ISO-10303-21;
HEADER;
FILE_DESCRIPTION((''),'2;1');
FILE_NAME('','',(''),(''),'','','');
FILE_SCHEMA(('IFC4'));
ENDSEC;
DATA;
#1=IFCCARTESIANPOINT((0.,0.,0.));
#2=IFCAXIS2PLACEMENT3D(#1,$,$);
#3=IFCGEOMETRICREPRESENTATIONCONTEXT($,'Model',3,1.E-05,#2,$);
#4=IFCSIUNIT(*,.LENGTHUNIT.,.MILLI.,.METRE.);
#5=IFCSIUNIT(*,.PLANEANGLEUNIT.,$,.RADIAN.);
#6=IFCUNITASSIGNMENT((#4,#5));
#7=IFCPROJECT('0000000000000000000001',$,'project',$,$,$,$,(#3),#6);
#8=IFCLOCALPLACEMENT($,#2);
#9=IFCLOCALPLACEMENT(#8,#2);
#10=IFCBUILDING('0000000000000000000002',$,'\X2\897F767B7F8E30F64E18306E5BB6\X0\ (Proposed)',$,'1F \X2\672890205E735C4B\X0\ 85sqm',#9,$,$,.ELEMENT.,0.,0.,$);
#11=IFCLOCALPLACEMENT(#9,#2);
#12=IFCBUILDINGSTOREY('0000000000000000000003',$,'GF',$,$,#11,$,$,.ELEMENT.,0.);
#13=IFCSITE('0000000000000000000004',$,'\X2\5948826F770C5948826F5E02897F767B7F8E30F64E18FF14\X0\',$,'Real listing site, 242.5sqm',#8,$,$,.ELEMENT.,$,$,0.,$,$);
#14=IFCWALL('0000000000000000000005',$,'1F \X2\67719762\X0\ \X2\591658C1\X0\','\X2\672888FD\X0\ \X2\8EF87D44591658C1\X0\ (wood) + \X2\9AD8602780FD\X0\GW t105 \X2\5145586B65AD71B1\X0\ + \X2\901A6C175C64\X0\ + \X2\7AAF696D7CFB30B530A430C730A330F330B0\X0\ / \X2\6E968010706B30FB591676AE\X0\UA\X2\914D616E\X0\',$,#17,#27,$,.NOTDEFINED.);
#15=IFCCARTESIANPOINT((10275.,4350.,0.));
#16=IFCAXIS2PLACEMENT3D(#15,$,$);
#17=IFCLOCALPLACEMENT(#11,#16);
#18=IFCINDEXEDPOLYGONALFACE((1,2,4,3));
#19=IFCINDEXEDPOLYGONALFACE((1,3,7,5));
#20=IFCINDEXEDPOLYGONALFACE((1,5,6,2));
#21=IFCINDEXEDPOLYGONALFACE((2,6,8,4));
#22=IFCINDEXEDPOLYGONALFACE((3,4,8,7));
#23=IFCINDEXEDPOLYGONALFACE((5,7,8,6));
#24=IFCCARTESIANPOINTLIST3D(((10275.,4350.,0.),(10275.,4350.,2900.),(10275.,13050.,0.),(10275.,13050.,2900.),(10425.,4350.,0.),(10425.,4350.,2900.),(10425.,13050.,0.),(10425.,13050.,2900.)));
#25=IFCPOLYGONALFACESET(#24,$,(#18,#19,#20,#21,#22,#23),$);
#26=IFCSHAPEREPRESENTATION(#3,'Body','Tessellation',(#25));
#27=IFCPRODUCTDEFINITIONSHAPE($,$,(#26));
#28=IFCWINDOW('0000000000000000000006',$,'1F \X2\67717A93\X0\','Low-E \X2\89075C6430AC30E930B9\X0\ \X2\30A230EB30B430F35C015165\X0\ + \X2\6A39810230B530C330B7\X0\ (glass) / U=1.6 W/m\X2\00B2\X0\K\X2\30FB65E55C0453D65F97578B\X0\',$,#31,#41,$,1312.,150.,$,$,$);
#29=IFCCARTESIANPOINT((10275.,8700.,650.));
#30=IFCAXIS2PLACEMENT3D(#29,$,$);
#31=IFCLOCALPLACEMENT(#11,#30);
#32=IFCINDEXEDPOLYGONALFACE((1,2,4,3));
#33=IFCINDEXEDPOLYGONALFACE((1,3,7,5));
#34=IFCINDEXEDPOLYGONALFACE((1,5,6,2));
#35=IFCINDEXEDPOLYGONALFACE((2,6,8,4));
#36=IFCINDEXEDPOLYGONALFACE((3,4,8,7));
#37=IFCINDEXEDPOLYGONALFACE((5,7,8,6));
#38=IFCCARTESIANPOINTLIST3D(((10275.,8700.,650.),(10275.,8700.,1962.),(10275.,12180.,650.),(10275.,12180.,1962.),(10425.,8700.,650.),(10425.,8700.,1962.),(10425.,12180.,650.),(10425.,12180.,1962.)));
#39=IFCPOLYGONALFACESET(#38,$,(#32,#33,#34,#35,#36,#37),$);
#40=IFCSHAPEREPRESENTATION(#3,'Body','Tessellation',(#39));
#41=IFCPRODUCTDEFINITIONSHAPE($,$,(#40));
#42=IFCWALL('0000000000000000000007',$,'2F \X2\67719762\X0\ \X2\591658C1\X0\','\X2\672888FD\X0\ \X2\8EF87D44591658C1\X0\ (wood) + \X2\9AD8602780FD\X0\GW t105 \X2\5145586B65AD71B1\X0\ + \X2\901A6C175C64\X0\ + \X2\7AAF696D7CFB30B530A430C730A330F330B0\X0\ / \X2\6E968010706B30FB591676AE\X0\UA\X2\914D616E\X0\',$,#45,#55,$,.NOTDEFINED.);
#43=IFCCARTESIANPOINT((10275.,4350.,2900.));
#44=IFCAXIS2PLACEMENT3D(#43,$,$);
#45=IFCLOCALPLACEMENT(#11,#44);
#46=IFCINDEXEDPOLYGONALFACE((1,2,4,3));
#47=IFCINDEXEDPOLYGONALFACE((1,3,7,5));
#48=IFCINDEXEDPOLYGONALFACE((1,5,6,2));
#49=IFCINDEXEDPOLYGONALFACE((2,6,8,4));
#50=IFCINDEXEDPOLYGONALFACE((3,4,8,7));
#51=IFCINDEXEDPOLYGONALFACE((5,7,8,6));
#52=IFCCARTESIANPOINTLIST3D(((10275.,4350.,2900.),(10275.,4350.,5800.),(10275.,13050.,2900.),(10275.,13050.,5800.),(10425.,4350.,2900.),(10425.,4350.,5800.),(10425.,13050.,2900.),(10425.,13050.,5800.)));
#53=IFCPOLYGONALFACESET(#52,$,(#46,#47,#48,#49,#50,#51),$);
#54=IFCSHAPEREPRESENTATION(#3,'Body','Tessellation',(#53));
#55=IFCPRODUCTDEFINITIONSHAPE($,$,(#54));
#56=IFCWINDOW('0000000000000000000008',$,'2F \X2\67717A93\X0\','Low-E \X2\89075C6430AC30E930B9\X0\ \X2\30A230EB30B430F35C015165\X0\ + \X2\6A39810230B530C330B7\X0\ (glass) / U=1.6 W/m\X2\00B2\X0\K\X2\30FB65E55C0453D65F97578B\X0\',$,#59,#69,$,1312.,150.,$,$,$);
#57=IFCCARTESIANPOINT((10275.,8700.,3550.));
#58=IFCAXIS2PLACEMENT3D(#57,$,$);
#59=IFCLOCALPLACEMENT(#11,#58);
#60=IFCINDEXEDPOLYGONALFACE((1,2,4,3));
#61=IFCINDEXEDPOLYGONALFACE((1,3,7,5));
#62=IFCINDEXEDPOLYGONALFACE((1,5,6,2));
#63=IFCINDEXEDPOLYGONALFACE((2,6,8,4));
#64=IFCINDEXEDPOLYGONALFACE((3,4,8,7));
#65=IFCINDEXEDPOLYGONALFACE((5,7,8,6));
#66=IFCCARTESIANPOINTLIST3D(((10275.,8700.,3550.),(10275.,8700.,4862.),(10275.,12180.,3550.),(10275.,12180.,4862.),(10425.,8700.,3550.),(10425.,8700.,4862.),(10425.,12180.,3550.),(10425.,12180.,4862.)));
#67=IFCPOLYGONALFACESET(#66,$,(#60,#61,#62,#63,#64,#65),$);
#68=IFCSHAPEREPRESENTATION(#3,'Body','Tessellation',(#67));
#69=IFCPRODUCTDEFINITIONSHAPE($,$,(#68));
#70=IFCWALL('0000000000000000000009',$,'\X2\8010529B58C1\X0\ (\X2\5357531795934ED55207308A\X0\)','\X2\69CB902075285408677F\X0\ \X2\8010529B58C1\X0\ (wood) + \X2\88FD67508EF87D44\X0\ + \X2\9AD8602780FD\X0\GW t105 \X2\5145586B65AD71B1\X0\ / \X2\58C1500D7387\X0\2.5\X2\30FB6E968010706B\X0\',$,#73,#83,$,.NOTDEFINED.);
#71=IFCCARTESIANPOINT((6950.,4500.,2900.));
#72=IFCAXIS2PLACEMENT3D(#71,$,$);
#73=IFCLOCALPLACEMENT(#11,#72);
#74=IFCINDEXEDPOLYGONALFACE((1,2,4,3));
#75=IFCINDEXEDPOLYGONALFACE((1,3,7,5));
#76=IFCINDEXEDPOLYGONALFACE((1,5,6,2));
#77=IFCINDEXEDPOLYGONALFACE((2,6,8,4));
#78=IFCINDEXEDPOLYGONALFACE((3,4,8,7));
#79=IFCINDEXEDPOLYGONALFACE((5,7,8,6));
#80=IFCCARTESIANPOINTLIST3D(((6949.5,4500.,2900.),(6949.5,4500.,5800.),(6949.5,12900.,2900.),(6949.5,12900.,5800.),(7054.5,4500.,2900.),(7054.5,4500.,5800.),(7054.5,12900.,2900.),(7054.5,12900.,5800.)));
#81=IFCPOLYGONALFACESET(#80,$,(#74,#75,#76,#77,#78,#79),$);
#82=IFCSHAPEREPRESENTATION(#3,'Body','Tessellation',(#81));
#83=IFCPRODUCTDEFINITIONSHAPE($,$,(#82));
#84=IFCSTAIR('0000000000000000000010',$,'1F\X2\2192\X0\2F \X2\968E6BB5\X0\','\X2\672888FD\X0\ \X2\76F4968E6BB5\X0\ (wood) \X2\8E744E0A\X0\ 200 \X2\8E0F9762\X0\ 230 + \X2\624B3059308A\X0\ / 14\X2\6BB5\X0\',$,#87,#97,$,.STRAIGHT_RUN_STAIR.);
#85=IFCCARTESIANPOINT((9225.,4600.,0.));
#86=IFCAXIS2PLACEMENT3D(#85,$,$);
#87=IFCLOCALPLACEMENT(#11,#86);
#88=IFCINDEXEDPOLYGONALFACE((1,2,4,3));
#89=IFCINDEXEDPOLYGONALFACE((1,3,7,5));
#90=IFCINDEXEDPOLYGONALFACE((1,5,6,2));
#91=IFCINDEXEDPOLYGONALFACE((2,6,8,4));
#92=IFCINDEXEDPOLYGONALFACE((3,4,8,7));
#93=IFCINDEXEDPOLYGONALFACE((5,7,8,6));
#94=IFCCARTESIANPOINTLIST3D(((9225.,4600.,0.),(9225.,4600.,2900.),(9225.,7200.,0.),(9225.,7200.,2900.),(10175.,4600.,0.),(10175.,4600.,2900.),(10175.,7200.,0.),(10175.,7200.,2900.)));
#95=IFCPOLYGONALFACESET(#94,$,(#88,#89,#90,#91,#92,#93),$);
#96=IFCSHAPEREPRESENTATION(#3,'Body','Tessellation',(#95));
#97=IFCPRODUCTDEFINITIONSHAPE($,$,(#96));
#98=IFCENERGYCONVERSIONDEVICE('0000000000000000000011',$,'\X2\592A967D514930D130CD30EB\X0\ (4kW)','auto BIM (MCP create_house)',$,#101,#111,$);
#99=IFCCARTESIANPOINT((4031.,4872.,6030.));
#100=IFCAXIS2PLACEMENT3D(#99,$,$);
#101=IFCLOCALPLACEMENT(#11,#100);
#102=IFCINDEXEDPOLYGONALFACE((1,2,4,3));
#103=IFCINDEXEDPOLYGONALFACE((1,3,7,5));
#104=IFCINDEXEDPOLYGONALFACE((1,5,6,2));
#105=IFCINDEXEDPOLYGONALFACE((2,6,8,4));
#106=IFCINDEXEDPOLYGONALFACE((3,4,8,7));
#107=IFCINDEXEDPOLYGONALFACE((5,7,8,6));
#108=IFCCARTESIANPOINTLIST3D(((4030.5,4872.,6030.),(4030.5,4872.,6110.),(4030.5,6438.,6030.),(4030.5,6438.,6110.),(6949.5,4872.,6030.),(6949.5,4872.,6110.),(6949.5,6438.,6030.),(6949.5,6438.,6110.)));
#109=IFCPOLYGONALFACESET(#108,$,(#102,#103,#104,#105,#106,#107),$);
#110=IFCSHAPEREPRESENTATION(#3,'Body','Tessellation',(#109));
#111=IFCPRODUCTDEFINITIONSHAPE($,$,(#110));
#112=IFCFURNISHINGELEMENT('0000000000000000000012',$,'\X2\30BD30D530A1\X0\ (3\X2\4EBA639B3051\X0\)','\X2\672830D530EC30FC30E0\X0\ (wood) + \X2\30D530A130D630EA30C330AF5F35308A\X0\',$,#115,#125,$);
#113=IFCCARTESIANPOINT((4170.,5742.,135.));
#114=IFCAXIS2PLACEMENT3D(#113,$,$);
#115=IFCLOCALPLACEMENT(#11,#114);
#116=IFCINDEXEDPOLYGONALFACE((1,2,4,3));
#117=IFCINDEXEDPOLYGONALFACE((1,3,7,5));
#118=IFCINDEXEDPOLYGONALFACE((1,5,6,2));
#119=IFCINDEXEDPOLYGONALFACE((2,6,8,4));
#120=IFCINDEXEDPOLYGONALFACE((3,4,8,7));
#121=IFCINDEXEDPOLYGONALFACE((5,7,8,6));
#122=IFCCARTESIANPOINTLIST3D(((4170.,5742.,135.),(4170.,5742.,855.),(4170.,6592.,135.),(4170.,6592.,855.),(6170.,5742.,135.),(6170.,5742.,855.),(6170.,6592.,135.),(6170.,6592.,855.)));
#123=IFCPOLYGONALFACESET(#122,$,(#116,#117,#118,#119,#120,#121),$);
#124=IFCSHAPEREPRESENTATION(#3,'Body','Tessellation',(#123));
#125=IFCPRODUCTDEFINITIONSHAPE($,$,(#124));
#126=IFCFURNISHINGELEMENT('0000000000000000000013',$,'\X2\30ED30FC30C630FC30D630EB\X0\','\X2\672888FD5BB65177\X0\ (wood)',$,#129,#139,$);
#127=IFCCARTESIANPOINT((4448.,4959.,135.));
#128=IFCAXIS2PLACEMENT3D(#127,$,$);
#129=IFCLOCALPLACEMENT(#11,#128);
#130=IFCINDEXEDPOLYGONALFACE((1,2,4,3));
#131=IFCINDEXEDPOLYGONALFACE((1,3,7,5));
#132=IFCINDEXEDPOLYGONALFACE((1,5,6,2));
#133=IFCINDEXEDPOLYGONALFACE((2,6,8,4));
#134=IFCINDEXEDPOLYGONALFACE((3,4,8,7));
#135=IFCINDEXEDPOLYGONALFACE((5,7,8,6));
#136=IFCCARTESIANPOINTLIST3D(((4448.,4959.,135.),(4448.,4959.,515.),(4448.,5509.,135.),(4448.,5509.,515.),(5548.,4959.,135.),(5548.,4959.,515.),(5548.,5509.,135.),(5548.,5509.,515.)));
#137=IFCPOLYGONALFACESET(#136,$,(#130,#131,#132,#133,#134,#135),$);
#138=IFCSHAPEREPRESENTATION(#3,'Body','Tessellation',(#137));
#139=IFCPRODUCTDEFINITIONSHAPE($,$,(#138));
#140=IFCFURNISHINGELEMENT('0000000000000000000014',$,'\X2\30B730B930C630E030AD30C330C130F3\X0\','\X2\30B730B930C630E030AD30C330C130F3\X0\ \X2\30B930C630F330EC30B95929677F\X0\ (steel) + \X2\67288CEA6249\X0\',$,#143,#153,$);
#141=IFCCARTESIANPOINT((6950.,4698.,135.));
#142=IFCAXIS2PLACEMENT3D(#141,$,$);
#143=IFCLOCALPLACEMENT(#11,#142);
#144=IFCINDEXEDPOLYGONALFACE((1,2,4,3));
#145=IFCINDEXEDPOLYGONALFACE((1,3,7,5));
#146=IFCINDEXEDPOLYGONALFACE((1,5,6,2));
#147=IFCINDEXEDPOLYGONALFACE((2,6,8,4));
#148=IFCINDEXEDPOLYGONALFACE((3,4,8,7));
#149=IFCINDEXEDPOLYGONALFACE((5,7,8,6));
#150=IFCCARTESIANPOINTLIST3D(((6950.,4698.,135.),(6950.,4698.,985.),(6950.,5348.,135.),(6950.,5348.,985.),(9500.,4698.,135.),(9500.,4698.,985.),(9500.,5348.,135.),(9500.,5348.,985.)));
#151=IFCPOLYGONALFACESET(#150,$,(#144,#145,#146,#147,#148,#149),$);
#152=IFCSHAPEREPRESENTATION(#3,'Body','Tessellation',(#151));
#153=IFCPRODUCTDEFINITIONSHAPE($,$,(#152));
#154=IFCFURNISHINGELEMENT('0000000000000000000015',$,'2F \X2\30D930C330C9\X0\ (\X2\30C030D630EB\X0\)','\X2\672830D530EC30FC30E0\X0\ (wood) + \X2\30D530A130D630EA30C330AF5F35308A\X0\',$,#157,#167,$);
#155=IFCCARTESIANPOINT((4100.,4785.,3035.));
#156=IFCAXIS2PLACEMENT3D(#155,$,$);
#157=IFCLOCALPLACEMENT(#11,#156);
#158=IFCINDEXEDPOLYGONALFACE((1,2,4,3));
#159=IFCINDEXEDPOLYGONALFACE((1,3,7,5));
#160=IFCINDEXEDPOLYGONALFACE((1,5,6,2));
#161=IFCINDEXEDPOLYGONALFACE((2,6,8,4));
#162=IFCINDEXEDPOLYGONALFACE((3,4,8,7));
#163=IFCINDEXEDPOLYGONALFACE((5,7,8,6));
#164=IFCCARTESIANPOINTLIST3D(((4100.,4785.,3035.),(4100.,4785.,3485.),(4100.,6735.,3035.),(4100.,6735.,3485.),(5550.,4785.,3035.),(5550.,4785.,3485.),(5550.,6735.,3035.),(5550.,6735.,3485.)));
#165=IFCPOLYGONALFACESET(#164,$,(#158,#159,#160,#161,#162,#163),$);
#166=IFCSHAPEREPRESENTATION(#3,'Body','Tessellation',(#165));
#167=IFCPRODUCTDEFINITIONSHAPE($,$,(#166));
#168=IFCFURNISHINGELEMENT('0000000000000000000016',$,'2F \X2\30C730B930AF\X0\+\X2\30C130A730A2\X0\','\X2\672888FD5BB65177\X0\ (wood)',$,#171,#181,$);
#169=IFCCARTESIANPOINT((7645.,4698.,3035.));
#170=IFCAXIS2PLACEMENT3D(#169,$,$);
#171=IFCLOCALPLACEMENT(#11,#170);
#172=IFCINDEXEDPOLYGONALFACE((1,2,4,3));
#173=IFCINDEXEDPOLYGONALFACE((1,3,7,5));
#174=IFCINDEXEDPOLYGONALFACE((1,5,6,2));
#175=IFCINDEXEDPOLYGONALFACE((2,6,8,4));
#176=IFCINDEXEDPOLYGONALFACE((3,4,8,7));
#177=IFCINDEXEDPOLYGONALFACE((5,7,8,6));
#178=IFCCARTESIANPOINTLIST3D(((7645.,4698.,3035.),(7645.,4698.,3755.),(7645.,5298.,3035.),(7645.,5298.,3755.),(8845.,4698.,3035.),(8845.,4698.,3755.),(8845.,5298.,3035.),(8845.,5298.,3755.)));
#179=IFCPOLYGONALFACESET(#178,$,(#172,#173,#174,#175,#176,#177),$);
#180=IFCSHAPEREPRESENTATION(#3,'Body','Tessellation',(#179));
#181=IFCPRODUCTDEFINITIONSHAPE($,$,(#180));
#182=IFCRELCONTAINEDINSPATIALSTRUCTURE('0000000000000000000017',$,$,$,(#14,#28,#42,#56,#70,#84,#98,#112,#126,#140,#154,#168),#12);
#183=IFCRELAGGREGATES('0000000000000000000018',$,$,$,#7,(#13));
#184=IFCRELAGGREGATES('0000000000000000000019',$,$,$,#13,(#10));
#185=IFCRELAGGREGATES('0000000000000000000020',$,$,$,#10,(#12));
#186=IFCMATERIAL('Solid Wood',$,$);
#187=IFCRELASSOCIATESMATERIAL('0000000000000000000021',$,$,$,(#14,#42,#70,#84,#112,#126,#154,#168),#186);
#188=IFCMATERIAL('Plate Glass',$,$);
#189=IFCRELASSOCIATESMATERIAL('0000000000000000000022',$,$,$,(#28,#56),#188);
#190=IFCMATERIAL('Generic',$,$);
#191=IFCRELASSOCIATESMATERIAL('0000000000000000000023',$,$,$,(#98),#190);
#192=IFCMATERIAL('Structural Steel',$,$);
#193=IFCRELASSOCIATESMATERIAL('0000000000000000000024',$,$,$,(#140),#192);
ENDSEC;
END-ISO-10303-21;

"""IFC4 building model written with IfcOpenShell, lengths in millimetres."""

from ifc_helpers import new_model, si_unit, frame, frame_2d, origin, place, context, project, spatial, rectangle, extrude, material, element, fill, save


model = new_model("IFC4")

# Units and contexts
model_context = context("Model", 3, precision=1e-05, world=origin())
ifc_project = project(units=[si_unit("LENGTHUNIT", "METRE", prefix="MILLI"), si_unit("PLANEANGLEUNIT", "RADIAN")], contexts=[model_context])

# Site, building, storey
site_placement = place(None, origin())
site = spatial("IfcSite", under=ifc_project, at=site_placement, Name="奈良県奈良市西登美ヶ丘４", ObjectType="Real listing site, 242.5sqm", CompositionType="ELEMENT", RefElevation=0.0)
building_placement = place(site_placement, origin())
building = spatial("IfcBuilding", under=site, at=building_placement, Name="西登美ヶ丘の家 (Proposed)", ObjectType="1F 木造平屋 85sqm", CompositionType="ELEMENT", ElevationOfRefHeight=0.0, ElevationOfTerrain=0.0)
storey_placement = place(building_placement, origin())
storey = spatial("IfcBuildingStorey", under=building, at=storey_placement, Name="GF", CompositionType="ELEMENT", Elevation=0.0)

# Wall, opening, window
ifc_material_1 = material(Name="Solid Wood")
wall_1_placement = place(storey_placement, frame((10275.0, 4350.0, 0.0)))
wall_1 = element("IfcWall", 1, at=wall_1_placement, inside=storey, material=ifc_material_1, Name="1F 東面 外壁", Description="木製 軸組外壁 (wood) + 高性能GW t105 充填断熱 + 通気層 + 窯業系サイディング / 準耐火・外皮UA配慮", PredefinedType="NOTDEFINED", context=model_context, shape_type="SweptSolid", body=[
    extrude(rectangle(XDim=150.0, YDim=8700.0, at=frame_2d((75.0, 4350.0))), frame((10275.0, 4350.0, 0.0)), (0.0, 0.0, 1.0), 2900.0),
])
opening_1_placement = place(storey_placement, frame((10275.0, 8700.0, 650.0)))
opening_1 = element("IfcOpeningElement", 2, at=opening_1_placement, cuts=wall_1, PredefinedType="NOTDEFINED", context=model_context, shape_type="SweptSolid", body=[
    extrude(rectangle(XDim=150.0, YDim=3480.0, at=frame_2d((75.0, 1740.0))), frame((10275.0, 8700.0, 650.0)), (0.0, 0.0, 1.0), 1312.0),
])
ifc_material_2 = material(Name="Plate Glass")
window_1_placement = place(storey_placement, frame((10275.0, 8700.0, 650.0)))
window_1 = element("IfcWindow", 3, at=window_1_placement, inside=storey, material=ifc_material_2, Name="1F 東窓", Description="Low-E 複層ガラス アルゴン封入 + 樹脂サッシ (glass) / U=1.6 W/m²K・日射取得型", OverallHeight=1312.0, OverallWidth=150.0, context=model_context, shape_type="SweptSolid", body=[
    extrude(rectangle(XDim=150.0, YDim=3480.0, at=frame_2d((75.0, 1740.0))), frame((10275.0, 8700.0, 650.0)), (0.0, 0.0, 1.0), 1312.0),
])
fill(opening_1, window_1)

# Wall, opening, window
wall_2_placement = place(storey_placement, frame((10275.0, 4350.0, 2900.0)))
wall_2 = element("IfcWall", 4, at=wall_2_placement, inside=storey, material=ifc_material_1, Name="2F 東面 外壁", Description="木製 軸組外壁 (wood) + 高性能GW t105 充填断熱 + 通気層 + 窯業系サイディング / 準耐火・外皮UA配慮", PredefinedType="NOTDEFINED", context=model_context, shape_type="SweptSolid", body=[
    extrude(rectangle(XDim=150.0, YDim=8700.0, at=frame_2d((75.0, 4350.0))), frame((10275.0, 4350.0, 2900.0)), (0.0, 0.0, 1.0), 2900.0),
])
opening_2_placement = place(storey_placement, frame((10275.0, 8700.0, 3550.0)))
opening_2 = element("IfcOpeningElement", 5, at=opening_2_placement, cuts=wall_2, PredefinedType="NOTDEFINED", context=model_context, shape_type="SweptSolid", body=[
    extrude(rectangle(XDim=150.0, YDim=3480.0, at=frame_2d((75.0, 1740.0))), frame((10275.0, 8700.0, 3550.0)), (0.0, 0.0, 1.0), 1312.0),
])
window_2_placement = place(storey_placement, frame((10275.0, 8700.0, 3550.0)))
window_2 = element("IfcWindow", 6, at=window_2_placement, inside=storey, material=ifc_material_2, Name="2F 東窓", Description="Low-E 複層ガラス アルゴン封入 + 樹脂サッシ (glass) / U=1.6 W/m²K・日射取得型", OverallHeight=1312.0, OverallWidth=150.0, context=model_context, shape_type="SweptSolid", body=[
    extrude(rectangle(XDim=150.0, YDim=3480.0, at=frame_2d((75.0, 1740.0))), frame((10275.0, 8700.0, 3550.0)), (0.0, 0.0, 1.0), 1312.0),
])
fill(opening_2, window_2)

# Wall
wall_3_placement = place(storey_placement, frame((6950.0, 4500.0, 2900.0)))
element("IfcWall", 7, at=wall_3_placement, inside=storey, material=ifc_material_1, Name="耐力壁 (南北間仕切り)", Description="構造用合板 耐力壁 (wood) + 製材軸組 + 高性能GW t105 充填断熱 / 壁倍率2.5・準耐火", PredefinedType="NOTDEFINED", context=model_context, shape_type="SweptSolid", body=[
    extrude(rectangle(XDim=105.0, YDim=8400.0, at=frame_2d((52.0, 4200.0))), frame((6950.0, 4500.0, 2900.0)), (0.0, 0.0, 1.0), 2900.0),
])

# Stair
stair_placement = place(storey_placement, frame((9225.0, 4600.0, 0.0)))
element("IfcStair", 8, at=stair_placement, inside=storey, material=ifc_material_1, Name="1F→2F 階段", Description="木製 直階段 (wood) 蹴上 200 踏面 230 + 手すり / 14段", PredefinedType="STRAIGHT_RUN_STAIR", context=model_context, shape_type="SweptSolid", body=[
    extrude(rectangle(XDim=950.0, YDim=2600.0, at=frame_2d((475.0, 1300.0))), frame((9225.0, 4600.0, 0.0)), (0.0, 0.0, 1.0), 2900.0),
])

# Energy conversion device
ifc_material_3 = material(Name="Generic")
energy_conversion_device_placement = place(storey_placement, frame((4031.0, 4872.0, 6030.0)))
element("IfcEnergyConversionDevice", 9, at=energy_conversion_device_placement, inside=storey, material=ifc_material_3, Name="太陽光パネル (4kW)", Description="auto BIM (MCP create_house)", context=model_context, shape_type="SweptSolid", body=[
    extrude(rectangle(XDim=2919.0, YDim=1566.0, at=frame_2d((1459.0, 783.0))), frame((4031.0, 4872.0, 6030.0)), (0.0, 0.0, 1.0), 80.0),
])

# Furnishing elements
furnishing_1_placement = place(storey_placement, frame((4170.0, 5742.0, 135.0)))
element("IfcFurnishingElement", 10, at=furnishing_1_placement, inside=storey, material=ifc_material_1, Name="ソファ (3人掛け)", Description="木フレーム (wood) + ファブリック張り", context=model_context, shape_type="SweptSolid", body=[
    extrude(rectangle(XDim=2000.0, YDim=850.0, at=frame_2d((1000.0, 425.0))), frame((4170.0, 5742.0, 135.0)), (0.0, 0.0, 1.0), 720.0),
])
furnishing_2_placement = place(storey_placement, frame((4448.0, 4959.0, 135.0)))
element("IfcFurnishingElement", 11, at=furnishing_2_placement, inside=storey, material=ifc_material_1, Name="ローテーブル", Description="木製家具 (wood)", context=model_context, shape_type="SweptSolid", body=[
    extrude(rectangle(XDim=1100.0, YDim=550.0, at=frame_2d((550.0, 275.0))), frame((4448.0, 4959.0, 135.0)), (0.0, 0.0, 1.0), 380.0),
])
ifc_material_4 = material(Name="Structural Steel")
furnishing_3_placement = place(storey_placement, frame((6950.0, 4698.0, 135.0)))
element("IfcFurnishingElement", 12, at=furnishing_3_placement, inside=storey, material=ifc_material_4, Name="システムキッチン", Description="システムキッチン ステンレス天板 (steel) + 木質扉", context=model_context, shape_type="SweptSolid", body=[
    extrude(rectangle(XDim=2550.0, YDim=650.0, at=frame_2d((1275.0, 325.0))), frame((6950.0, 4698.0, 135.0)), (0.0, 0.0, 1.0), 850.0),
])
furnishing_4_placement = place(storey_placement, frame((4100.0, 4785.0, 3035.0)))
element("IfcFurnishingElement", 13, at=furnishing_4_placement, inside=storey, material=ifc_material_1, Name="2F ベッド (ダブル)", Description="木フレーム (wood) + ファブリック張り", context=model_context, shape_type="SweptSolid", body=[
    extrude(rectangle(XDim=1450.0, YDim=1950.0, at=frame_2d((725.0, 975.0))), frame((4100.0, 4785.0, 3035.0)), (0.0, 0.0, 1.0), 450.0),
])
furnishing_5_placement = place(storey_placement, frame((7645.0, 4698.0, 3035.0)))
element("IfcFurnishingElement", 14, at=furnishing_5_placement, inside=storey, material=ifc_material_1, Name="2F デスク+チェア", Description="木製家具 (wood)", context=model_context, shape_type="SweptSolid", body=[
    extrude(rectangle(XDim=1200.0, YDim=600.0, at=frame_2d((600.0, 300.0))), frame((7645.0, 4698.0, 3035.0)), (0.0, 0.0, 1.0), 720.0),
])

save(model, "model.ifc")
